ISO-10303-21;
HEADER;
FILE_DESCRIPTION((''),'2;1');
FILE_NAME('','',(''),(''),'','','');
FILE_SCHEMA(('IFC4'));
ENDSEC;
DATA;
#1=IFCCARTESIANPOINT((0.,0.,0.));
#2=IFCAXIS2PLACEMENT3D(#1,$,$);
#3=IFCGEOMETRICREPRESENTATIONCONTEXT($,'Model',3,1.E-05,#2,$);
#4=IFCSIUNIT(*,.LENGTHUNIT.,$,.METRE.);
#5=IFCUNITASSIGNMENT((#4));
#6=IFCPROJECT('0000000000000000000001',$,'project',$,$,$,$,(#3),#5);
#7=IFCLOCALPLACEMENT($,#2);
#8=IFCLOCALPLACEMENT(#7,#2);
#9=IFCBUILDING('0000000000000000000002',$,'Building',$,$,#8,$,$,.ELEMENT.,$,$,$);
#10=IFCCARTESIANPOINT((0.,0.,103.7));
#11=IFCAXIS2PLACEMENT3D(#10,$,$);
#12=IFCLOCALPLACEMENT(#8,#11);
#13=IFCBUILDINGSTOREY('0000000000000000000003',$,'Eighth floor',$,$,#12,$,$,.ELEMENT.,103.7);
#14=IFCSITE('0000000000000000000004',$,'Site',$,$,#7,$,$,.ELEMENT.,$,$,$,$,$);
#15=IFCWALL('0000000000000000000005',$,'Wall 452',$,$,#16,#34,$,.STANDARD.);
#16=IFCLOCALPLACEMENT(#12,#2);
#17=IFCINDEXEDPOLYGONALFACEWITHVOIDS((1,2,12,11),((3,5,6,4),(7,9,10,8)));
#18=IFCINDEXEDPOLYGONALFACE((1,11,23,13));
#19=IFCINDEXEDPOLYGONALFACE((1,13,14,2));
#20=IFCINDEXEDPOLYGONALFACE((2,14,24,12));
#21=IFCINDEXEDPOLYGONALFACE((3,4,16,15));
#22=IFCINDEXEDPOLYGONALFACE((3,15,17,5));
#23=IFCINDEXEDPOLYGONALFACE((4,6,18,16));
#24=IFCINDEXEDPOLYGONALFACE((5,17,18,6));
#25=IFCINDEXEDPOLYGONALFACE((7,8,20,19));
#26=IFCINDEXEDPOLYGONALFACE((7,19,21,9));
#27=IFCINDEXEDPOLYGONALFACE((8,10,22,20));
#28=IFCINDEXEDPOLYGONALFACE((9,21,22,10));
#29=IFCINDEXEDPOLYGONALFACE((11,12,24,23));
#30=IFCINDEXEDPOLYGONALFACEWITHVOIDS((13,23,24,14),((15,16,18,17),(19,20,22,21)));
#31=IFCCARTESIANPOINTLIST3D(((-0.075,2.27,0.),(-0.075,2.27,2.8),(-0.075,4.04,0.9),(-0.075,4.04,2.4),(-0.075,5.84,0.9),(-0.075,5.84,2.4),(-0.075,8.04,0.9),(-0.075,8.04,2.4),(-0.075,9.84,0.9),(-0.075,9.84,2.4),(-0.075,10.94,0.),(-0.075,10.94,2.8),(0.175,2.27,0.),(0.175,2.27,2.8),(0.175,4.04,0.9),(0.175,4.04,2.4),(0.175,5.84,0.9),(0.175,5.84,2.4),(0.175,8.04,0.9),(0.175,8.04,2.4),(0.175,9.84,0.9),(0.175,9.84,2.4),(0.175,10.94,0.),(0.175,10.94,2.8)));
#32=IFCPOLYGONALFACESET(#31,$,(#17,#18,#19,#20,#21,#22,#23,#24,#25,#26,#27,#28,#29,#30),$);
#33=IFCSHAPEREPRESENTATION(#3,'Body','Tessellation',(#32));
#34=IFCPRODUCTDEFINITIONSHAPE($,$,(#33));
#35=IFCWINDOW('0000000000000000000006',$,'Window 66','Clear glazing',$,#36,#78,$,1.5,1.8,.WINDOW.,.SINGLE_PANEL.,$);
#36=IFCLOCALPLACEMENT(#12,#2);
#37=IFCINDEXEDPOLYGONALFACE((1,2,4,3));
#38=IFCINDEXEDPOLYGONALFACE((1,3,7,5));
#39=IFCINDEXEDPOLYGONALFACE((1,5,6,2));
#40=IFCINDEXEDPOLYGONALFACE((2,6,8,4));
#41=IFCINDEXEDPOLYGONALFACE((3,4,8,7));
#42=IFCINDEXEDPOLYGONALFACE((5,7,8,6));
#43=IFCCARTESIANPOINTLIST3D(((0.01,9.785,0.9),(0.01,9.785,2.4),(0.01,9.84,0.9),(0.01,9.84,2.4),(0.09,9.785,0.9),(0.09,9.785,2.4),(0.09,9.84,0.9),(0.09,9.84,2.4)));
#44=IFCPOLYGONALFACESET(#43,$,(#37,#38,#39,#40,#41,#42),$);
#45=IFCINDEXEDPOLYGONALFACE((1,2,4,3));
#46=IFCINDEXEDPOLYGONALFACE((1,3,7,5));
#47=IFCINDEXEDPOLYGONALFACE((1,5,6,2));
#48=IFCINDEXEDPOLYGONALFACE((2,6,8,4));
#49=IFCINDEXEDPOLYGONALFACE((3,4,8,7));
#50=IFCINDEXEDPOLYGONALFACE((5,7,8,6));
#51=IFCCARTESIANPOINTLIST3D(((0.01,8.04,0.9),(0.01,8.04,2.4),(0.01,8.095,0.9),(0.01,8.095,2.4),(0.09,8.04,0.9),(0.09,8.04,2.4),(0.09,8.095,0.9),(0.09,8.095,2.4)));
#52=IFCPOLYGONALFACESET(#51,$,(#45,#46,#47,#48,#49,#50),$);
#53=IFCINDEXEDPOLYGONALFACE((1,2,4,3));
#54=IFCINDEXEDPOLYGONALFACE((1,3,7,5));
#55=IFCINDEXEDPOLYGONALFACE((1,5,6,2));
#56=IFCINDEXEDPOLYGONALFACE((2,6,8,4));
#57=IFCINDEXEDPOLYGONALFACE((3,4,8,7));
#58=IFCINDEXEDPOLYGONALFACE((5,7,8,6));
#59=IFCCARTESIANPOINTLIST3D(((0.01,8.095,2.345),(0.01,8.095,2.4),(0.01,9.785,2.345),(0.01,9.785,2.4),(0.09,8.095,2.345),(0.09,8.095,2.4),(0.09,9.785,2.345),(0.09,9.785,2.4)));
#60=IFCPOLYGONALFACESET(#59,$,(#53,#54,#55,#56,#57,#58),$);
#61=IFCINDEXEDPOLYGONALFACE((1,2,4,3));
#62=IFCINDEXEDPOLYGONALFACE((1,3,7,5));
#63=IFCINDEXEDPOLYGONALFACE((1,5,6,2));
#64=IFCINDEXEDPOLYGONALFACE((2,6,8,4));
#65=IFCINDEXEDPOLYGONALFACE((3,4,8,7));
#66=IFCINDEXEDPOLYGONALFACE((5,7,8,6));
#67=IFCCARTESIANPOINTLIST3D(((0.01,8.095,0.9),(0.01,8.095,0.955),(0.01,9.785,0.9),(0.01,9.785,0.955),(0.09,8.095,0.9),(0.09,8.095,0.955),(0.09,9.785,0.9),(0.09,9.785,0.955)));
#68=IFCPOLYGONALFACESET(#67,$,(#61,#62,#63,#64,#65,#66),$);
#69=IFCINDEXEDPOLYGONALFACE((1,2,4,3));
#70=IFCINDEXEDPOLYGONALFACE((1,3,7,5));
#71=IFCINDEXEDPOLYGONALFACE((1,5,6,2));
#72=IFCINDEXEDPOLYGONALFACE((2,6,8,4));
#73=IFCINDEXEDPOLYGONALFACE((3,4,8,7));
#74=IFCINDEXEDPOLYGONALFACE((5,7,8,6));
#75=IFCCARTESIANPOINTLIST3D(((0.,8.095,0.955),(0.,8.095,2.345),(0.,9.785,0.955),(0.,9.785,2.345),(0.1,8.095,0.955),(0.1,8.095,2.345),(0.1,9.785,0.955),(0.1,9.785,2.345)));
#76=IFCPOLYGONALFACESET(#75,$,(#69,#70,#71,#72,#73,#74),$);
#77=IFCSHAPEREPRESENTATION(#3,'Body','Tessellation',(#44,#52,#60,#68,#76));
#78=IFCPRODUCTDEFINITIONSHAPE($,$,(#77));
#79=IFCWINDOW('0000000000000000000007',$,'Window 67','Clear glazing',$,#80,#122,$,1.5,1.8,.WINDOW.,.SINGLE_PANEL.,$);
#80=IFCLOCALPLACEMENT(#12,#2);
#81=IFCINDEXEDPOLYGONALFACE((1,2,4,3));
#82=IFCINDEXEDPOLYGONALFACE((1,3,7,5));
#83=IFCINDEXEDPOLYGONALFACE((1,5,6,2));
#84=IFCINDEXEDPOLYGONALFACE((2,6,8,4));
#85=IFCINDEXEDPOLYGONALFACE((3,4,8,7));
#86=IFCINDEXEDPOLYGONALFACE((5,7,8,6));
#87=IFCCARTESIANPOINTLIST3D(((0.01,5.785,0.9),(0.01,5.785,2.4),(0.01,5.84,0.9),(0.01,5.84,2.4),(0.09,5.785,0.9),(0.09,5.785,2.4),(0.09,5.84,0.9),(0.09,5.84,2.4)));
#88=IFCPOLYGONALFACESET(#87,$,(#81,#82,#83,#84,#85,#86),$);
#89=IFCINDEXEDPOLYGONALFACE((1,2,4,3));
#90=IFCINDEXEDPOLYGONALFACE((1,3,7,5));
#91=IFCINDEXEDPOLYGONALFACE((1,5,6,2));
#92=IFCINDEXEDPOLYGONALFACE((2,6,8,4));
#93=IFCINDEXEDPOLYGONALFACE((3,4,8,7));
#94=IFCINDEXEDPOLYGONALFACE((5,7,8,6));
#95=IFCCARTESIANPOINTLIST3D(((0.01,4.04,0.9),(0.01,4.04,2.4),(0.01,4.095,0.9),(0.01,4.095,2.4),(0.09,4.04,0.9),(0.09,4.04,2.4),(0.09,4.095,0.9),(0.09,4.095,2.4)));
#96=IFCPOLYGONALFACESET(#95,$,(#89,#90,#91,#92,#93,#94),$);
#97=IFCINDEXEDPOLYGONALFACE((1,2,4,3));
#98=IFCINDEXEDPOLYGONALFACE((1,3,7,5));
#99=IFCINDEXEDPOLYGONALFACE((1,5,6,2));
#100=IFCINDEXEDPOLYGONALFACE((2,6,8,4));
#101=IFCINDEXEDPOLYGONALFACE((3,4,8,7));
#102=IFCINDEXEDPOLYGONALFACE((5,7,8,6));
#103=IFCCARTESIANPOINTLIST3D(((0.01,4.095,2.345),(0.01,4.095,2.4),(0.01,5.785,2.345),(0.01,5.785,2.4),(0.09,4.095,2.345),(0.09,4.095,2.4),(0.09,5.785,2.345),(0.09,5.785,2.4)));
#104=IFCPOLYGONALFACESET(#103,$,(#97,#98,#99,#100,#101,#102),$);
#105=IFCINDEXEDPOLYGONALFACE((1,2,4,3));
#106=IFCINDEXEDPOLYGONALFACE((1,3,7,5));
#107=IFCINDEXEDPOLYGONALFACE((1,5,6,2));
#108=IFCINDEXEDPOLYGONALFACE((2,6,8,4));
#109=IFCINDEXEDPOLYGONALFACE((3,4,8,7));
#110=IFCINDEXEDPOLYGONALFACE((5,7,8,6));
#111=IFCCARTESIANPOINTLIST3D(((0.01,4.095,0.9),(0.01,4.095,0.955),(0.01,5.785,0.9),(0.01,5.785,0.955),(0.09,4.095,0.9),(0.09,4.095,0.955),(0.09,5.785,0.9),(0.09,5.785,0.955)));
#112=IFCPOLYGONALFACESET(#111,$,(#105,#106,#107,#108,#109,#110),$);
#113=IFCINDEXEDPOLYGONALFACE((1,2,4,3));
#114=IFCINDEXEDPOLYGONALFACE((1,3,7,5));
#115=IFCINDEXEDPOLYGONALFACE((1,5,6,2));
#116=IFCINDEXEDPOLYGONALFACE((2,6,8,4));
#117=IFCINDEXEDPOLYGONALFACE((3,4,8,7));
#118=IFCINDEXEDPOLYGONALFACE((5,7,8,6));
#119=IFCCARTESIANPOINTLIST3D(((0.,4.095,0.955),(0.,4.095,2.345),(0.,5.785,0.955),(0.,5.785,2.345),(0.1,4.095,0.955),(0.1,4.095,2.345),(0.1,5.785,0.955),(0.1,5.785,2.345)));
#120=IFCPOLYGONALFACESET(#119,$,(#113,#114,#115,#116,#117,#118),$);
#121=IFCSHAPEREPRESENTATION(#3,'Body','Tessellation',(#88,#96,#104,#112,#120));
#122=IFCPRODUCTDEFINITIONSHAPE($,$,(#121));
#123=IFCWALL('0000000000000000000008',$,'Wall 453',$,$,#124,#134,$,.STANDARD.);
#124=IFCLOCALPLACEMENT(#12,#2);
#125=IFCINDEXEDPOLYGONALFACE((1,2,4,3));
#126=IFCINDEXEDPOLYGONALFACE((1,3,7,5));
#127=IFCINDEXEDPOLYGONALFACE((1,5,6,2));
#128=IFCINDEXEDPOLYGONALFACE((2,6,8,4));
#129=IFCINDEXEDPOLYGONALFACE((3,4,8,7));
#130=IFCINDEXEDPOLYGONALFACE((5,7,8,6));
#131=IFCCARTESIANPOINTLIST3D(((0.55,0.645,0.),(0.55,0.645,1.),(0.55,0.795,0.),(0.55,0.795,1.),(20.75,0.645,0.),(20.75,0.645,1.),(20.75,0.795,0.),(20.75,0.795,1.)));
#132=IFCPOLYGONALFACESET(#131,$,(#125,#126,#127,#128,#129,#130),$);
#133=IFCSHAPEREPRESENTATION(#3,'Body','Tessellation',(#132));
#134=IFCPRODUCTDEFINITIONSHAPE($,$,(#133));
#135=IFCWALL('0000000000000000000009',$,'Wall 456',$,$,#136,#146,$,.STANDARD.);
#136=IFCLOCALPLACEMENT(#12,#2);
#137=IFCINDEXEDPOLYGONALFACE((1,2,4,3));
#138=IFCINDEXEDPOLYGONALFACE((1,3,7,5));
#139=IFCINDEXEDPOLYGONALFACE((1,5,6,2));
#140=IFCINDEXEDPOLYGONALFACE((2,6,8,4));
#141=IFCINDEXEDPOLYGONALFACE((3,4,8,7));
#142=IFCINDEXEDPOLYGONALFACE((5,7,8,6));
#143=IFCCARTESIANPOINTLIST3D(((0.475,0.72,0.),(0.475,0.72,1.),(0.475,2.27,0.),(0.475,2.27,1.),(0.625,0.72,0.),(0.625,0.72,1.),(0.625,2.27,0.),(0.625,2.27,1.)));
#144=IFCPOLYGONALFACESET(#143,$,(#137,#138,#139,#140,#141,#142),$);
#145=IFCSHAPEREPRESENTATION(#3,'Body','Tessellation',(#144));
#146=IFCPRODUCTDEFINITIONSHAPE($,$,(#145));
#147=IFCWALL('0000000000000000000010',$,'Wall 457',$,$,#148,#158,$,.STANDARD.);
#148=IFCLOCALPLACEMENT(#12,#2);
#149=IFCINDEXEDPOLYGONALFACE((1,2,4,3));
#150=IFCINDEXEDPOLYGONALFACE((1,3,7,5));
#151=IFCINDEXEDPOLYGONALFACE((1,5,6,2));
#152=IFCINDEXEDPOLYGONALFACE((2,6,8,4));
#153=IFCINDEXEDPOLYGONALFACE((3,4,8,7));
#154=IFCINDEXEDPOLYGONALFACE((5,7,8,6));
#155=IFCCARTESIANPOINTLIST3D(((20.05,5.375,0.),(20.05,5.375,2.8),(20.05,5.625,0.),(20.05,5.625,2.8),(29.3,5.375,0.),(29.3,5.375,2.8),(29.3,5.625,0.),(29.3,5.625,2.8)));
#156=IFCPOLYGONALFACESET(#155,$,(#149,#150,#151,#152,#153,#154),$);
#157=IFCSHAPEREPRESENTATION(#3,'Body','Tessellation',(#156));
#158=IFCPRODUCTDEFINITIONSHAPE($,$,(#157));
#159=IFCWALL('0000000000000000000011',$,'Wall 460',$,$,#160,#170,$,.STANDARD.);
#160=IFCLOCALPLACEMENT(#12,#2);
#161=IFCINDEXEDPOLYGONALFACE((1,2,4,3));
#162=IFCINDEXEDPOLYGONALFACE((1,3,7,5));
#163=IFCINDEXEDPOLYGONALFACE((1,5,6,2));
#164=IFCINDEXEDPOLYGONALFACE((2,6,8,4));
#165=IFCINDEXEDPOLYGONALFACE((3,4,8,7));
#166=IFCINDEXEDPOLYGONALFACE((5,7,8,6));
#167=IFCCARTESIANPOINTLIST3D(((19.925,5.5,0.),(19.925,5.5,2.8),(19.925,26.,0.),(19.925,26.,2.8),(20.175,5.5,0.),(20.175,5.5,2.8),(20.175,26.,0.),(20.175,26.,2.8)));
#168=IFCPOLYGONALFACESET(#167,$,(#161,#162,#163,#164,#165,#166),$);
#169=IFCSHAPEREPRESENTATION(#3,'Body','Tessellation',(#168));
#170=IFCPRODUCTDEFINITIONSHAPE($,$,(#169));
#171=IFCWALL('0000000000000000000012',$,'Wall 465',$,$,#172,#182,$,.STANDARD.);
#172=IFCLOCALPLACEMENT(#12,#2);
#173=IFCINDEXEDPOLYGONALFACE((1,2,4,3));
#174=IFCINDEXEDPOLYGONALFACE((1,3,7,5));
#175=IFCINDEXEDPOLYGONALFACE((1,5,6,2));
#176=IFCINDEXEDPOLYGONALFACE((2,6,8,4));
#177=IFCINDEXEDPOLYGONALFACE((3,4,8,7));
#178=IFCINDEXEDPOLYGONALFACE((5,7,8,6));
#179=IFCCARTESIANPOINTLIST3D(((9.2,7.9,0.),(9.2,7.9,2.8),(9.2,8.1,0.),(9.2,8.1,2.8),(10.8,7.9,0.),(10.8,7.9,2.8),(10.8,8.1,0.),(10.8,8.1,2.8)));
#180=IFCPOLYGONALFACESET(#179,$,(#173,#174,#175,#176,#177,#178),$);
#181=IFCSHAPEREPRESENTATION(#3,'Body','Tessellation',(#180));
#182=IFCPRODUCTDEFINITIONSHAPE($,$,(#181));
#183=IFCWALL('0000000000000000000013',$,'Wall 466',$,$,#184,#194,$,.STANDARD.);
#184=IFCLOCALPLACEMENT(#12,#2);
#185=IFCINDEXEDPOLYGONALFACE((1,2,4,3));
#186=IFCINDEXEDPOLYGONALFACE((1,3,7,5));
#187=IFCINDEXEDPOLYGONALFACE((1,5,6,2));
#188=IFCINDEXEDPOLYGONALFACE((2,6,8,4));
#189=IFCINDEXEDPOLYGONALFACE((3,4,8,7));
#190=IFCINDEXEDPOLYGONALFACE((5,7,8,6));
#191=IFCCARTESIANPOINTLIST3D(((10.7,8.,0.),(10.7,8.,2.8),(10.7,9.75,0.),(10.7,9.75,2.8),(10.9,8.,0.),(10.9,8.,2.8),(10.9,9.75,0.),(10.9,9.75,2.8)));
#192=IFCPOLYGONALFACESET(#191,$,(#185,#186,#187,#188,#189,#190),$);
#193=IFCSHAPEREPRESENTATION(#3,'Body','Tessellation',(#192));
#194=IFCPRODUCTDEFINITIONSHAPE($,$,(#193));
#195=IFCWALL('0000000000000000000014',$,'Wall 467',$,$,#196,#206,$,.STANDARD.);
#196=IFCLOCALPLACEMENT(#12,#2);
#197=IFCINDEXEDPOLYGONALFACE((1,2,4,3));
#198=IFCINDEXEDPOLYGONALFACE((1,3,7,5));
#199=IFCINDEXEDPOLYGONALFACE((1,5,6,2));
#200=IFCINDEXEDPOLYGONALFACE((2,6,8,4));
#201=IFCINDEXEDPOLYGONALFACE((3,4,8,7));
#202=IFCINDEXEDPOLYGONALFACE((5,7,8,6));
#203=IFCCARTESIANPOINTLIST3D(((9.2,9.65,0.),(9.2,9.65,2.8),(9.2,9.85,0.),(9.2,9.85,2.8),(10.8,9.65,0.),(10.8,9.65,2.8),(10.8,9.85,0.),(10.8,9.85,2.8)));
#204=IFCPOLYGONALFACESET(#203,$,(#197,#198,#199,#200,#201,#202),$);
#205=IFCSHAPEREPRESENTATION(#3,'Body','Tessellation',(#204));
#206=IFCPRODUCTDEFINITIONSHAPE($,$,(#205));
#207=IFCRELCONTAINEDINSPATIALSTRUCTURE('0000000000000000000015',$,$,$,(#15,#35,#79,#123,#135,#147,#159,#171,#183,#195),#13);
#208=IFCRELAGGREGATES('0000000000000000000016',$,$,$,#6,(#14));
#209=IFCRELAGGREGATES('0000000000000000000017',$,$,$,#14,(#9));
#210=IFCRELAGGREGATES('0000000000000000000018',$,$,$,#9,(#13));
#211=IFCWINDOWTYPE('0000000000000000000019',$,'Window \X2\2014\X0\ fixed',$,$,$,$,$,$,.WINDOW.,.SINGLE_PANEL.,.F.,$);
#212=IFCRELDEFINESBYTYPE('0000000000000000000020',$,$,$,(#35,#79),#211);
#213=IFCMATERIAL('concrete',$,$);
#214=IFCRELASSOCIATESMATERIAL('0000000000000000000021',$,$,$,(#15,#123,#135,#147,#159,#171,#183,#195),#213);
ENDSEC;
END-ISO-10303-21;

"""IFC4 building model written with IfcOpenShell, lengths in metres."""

from ifc_helpers import new_model, si_unit, frame, frame_2d, origin, place, context, project, spatial, rectangle, extrude, material, type_object, element, fill, save


model = new_model("IFC4")

# Units and contexts
model_context = context("Model", 3, precision=1e-05, world=origin())
ifc_project = project(units=[si_unit("LENGTHUNIT", "METRE")], contexts=[model_context])

# Site, building, storey
site_placement = place(None, origin())
site = spatial("IfcSite", under=ifc_project, at=site_placement, Name="Site", CompositionType="ELEMENT")
building_placement = place(site_placement, origin())
building = spatial("IfcBuilding", under=site, at=building_placement, Name="Building", CompositionType="ELEMENT")
storey_placement = place(building_placement, frame((0.0, 0.0, 103.7)))
storey = spatial("IfcBuildingStorey", under=building, at=storey_placement, Name="Eighth floor", CompositionType="ELEMENT", Elevation=103.7)

# Shared definitions
ifc_material = material(Name="concrete")

# Shared definitions
window_type = type_object("IfcWindowType", Name="Window — fixed", ParameterTakesPrecedence=False, PartitioningType="SINGLE_PANEL", PredefinedType="WINDOW")

# Wall, openings, windows
wall_1_placement = place(storey_placement, frame((0.05, 10.94, 0.0), z_axis=(0.0, 0.0, 1.0), x_axis=(0.0, -1.0, 0.0)))
wall_1 = element("IfcWall", 1, at=wall_1_placement, inside=storey, material=ifc_material, Name="Wall 452", PredefinedType="STANDARD", context=model_context, shape_type="SweptSolid", body=[
    extrude(rectangle(XDim=8.67, YDim=0.25, at=frame_2d((4.335, 0.0))), origin(), (0.0, 0.0, 1.0), 2.8),
])
opening_1_placement = place(storey_placement, frame((0.05, 9.84, 0.9), z_axis=(0.0, 0.0, 1.0), x_axis=(0.0, -1.0, 0.0)))
opening_1 = element("IfcOpeningElement", 2, at=opening_1_placement, cuts=wall_1, PredefinedType="OPENING", context=model_context, shape_type="SweptSolid", body=[
    extrude(rectangle(XDim=1.8, YDim=0.31, at=frame_2d((0.9, 0.0))), origin(), (0.0, 0.0, 1.0), 1.5),
])
opening_2_placement = place(storey_placement, frame((0.05, 5.84, 0.9), z_axis=(0.0, 0.0, 1.0), x_axis=(0.0, -1.0, 0.0)))
opening_2 = element("IfcOpeningElement", 3, at=opening_2_placement, cuts=wall_1, PredefinedType="OPENING", context=model_context, shape_type="SweptSolid", body=[
    extrude(rectangle(XDim=1.8, YDim=0.31, at=frame_2d((0.9, 0.0))), origin(), (0.0, 0.0, 1.0), 1.5),
])
window_1_placement = place(storey_placement, frame((0.05, 9.84, 0.9), z_axis=(0.0, 0.0, 1.0), x_axis=(0.0, -1.0, 0.0)))
window_1 = element("IfcWindow", 4, at=window_1_placement, inside=storey, type_object=window_type, Name="Window 66", Description="Clear glazing", OverallHeight=1.5, OverallWidth=1.8, PartitioningType="SINGLE_PANEL", PredefinedType="WINDOW", context=model_context, shape_type="SweptSolid", body=[
    extrude(rectangle(XDim=0.055, YDim=0.08, at=frame_2d((0.0275, 0.0))), origin(), (0.0, 0.0, 1.0), 1.5),
    extrude(rectangle(XDim=0.055, YDim=0.08, at=frame_2d((1.7725, 0.0))), origin(), (0.0, 0.0, 1.0), 1.5),
    extrude(rectangle(XDim=1.69, YDim=0.08, at=frame_2d((0.9, 0.0))), frame((0.0, 0.0, 1.445)), (0.0, 0.0, 1.0), 0.055),
    extrude(rectangle(XDim=1.69, YDim=0.08, at=frame_2d((0.9, 0.0))), origin(), (0.0, 0.0, 1.0), 0.055),
    extrude(rectangle(XDim=1.69, YDim=0.1, at=frame_2d((0.9, 0.0))), frame((0.0, 0.0, 0.055)), (0.0, 0.0, 1.0), 1.39),
])
fill(opening_1, window_1)
window_2_placement = place(storey_placement, frame((0.05, 5.84, 0.9), z_axis=(0.0, 0.0, 1.0), x_axis=(0.0, -1.0, 0.0)))
window_2 = element("IfcWindow", 5, at=window_2_placement, inside=storey, type_object=window_type, Name="Window 67", Description="Clear glazing", OverallHeight=1.5, OverallWidth=1.8, PartitioningType="SINGLE_PANEL", PredefinedType="WINDOW", context=model_context, shape_type="SweptSolid", body=[
    extrude(rectangle(XDim=0.055, YDim=0.08, at=frame_2d((0.0275, 0.0))), origin(), (0.0, 0.0, 1.0), 1.5),
    extrude(rectangle(XDim=0.055, YDim=0.08, at=frame_2d((1.7725, 0.0))), origin(), (0.0, 0.0, 1.0), 1.5),
    extrude(rectangle(XDim=1.69, YDim=0.08, at=frame_2d((0.9, 0.0))), frame((0.0, 0.0, 1.445)), (0.0, 0.0, 1.0), 0.055),
    extrude(rectangle(XDim=1.69, YDim=0.08, at=frame_2d((0.9, 0.0))), origin(), (0.0, 0.0, 1.0), 0.055),
    extrude(rectangle(XDim=1.69, YDim=0.1, at=frame_2d((0.9, 0.0))), frame((0.0, 0.0, 0.055)), (0.0, 0.0, 1.0), 1.39),
])
fill(opening_2, window_2)

# Walls
wall_2_placement = place(storey_placement, frame((0.55, 0.72, 0.0), z_axis=(0.0, 0.0, 1.0), x_axis=(1.0, 0.0, 0.0)))
element("IfcWall", 6, at=wall_2_placement, inside=storey, material=ifc_material, Name="Wall 453", PredefinedType="STANDARD", context=model_context, shape_type="SweptSolid", body=[
    extrude(rectangle(XDim=20.2, YDim=0.15, at=frame_2d((10.1, 0.0))), origin(), (0.0, 0.0, 1.0), 1.0),
])
wall_3_placement = place(storey_placement, frame((0.55, 2.27, 0.0), z_axis=(0.0, 0.0, 1.0), x_axis=(0.0, -1.0, 0.0)))
element("IfcWall", 7, at=wall_3_placement, inside=storey, material=ifc_material, Name="Wall 456", PredefinedType="STANDARD", context=model_context, shape_type="SweptSolid", body=[
    extrude(rectangle(XDim=1.55, YDim=0.15, at=frame_2d((0.775, 0.0))), origin(), (0.0, 0.0, 1.0), 1.0),
])
wall_4_placement = place(storey_placement, frame((20.05, 5.5, 0.0), z_axis=(0.0, 0.0, 1.0), x_axis=(1.0, 0.0, 0.0)))
element("IfcWall", 8, at=wall_4_placement, inside=storey, material=ifc_material, Name="Wall 457", PredefinedType="STANDARD", context=model_context, shape_type="SweptSolid", body=[
    extrude(rectangle(XDim=9.25, YDim=0.25, at=frame_2d((4.625, 0.0))), origin(), (0.0, 0.0, 1.0), 2.8),
])
wall_5_placement = place(storey_placement, frame((20.05, 26.0, 0.0), z_axis=(0.0, 0.0, 1.0), x_axis=(0.0, -1.0, 0.0)))
element("IfcWall", 9, at=wall_5_placement, inside=storey, material=ifc_material, Name="Wall 460", PredefinedType="STANDARD", context=model_context, shape_type="SweptSolid", body=[
    extrude(rectangle(XDim=20.5, YDim=0.25, at=frame_2d((10.25, 0.0))), origin(), (0.0, 0.0, 1.0), 2.8),
])
wall_6_placement = place(storey_placement, frame((9.2, 8.0, 0.0), z_axis=(0.0, 0.0, 1.0), x_axis=(1.0, 0.0, 0.0)))
element("IfcWall", 10, at=wall_6_placement, inside=storey, material=ifc_material, Name="Wall 465", PredefinedType="STANDARD", context=model_context, shape_type="SweptSolid", body=[
    extrude(rectangle(XDim=1.6, YDim=0.2, at=frame_2d((0.8, 0.0))), origin(), (0.0, 0.0, 1.0), 2.8),
])
wall_7_placement = place(storey_placement, frame((10.8, 8.0, 0.0), z_axis=(0.0, 0.0, 1.0), x_axis=(0.0, 1.0, 0.0)))
element("IfcWall", 11, at=wall_7_placement, inside=storey, material=ifc_material, Name="Wall 466", PredefinedType="STANDARD", context=model_context, shape_type="SweptSolid", body=[
    extrude(rectangle(XDim=1.75, YDim=0.2, at=frame_2d((0.875, 0.0))), origin(), (0.0, 0.0, 1.0), 2.8),
])
wall_8_placement = place(storey_placement, frame((10.8, 9.75, 0.0), z_axis=(0.0, 0.0, 1.0), x_axis=(-1.0, 0.0, 0.0)))
element("IfcWall", 12, at=wall_8_placement, inside=storey, material=ifc_material, Name="Wall 467", PredefinedType="STANDARD", context=model_context, shape_type="SweptSolid", body=[
    extrude(rectangle(XDim=1.6, YDim=0.2, at=frame_2d((0.8, 0.0))), origin(), (0.0, 0.0, 1.0), 2.8),
])

save(model, "model.ifc")
